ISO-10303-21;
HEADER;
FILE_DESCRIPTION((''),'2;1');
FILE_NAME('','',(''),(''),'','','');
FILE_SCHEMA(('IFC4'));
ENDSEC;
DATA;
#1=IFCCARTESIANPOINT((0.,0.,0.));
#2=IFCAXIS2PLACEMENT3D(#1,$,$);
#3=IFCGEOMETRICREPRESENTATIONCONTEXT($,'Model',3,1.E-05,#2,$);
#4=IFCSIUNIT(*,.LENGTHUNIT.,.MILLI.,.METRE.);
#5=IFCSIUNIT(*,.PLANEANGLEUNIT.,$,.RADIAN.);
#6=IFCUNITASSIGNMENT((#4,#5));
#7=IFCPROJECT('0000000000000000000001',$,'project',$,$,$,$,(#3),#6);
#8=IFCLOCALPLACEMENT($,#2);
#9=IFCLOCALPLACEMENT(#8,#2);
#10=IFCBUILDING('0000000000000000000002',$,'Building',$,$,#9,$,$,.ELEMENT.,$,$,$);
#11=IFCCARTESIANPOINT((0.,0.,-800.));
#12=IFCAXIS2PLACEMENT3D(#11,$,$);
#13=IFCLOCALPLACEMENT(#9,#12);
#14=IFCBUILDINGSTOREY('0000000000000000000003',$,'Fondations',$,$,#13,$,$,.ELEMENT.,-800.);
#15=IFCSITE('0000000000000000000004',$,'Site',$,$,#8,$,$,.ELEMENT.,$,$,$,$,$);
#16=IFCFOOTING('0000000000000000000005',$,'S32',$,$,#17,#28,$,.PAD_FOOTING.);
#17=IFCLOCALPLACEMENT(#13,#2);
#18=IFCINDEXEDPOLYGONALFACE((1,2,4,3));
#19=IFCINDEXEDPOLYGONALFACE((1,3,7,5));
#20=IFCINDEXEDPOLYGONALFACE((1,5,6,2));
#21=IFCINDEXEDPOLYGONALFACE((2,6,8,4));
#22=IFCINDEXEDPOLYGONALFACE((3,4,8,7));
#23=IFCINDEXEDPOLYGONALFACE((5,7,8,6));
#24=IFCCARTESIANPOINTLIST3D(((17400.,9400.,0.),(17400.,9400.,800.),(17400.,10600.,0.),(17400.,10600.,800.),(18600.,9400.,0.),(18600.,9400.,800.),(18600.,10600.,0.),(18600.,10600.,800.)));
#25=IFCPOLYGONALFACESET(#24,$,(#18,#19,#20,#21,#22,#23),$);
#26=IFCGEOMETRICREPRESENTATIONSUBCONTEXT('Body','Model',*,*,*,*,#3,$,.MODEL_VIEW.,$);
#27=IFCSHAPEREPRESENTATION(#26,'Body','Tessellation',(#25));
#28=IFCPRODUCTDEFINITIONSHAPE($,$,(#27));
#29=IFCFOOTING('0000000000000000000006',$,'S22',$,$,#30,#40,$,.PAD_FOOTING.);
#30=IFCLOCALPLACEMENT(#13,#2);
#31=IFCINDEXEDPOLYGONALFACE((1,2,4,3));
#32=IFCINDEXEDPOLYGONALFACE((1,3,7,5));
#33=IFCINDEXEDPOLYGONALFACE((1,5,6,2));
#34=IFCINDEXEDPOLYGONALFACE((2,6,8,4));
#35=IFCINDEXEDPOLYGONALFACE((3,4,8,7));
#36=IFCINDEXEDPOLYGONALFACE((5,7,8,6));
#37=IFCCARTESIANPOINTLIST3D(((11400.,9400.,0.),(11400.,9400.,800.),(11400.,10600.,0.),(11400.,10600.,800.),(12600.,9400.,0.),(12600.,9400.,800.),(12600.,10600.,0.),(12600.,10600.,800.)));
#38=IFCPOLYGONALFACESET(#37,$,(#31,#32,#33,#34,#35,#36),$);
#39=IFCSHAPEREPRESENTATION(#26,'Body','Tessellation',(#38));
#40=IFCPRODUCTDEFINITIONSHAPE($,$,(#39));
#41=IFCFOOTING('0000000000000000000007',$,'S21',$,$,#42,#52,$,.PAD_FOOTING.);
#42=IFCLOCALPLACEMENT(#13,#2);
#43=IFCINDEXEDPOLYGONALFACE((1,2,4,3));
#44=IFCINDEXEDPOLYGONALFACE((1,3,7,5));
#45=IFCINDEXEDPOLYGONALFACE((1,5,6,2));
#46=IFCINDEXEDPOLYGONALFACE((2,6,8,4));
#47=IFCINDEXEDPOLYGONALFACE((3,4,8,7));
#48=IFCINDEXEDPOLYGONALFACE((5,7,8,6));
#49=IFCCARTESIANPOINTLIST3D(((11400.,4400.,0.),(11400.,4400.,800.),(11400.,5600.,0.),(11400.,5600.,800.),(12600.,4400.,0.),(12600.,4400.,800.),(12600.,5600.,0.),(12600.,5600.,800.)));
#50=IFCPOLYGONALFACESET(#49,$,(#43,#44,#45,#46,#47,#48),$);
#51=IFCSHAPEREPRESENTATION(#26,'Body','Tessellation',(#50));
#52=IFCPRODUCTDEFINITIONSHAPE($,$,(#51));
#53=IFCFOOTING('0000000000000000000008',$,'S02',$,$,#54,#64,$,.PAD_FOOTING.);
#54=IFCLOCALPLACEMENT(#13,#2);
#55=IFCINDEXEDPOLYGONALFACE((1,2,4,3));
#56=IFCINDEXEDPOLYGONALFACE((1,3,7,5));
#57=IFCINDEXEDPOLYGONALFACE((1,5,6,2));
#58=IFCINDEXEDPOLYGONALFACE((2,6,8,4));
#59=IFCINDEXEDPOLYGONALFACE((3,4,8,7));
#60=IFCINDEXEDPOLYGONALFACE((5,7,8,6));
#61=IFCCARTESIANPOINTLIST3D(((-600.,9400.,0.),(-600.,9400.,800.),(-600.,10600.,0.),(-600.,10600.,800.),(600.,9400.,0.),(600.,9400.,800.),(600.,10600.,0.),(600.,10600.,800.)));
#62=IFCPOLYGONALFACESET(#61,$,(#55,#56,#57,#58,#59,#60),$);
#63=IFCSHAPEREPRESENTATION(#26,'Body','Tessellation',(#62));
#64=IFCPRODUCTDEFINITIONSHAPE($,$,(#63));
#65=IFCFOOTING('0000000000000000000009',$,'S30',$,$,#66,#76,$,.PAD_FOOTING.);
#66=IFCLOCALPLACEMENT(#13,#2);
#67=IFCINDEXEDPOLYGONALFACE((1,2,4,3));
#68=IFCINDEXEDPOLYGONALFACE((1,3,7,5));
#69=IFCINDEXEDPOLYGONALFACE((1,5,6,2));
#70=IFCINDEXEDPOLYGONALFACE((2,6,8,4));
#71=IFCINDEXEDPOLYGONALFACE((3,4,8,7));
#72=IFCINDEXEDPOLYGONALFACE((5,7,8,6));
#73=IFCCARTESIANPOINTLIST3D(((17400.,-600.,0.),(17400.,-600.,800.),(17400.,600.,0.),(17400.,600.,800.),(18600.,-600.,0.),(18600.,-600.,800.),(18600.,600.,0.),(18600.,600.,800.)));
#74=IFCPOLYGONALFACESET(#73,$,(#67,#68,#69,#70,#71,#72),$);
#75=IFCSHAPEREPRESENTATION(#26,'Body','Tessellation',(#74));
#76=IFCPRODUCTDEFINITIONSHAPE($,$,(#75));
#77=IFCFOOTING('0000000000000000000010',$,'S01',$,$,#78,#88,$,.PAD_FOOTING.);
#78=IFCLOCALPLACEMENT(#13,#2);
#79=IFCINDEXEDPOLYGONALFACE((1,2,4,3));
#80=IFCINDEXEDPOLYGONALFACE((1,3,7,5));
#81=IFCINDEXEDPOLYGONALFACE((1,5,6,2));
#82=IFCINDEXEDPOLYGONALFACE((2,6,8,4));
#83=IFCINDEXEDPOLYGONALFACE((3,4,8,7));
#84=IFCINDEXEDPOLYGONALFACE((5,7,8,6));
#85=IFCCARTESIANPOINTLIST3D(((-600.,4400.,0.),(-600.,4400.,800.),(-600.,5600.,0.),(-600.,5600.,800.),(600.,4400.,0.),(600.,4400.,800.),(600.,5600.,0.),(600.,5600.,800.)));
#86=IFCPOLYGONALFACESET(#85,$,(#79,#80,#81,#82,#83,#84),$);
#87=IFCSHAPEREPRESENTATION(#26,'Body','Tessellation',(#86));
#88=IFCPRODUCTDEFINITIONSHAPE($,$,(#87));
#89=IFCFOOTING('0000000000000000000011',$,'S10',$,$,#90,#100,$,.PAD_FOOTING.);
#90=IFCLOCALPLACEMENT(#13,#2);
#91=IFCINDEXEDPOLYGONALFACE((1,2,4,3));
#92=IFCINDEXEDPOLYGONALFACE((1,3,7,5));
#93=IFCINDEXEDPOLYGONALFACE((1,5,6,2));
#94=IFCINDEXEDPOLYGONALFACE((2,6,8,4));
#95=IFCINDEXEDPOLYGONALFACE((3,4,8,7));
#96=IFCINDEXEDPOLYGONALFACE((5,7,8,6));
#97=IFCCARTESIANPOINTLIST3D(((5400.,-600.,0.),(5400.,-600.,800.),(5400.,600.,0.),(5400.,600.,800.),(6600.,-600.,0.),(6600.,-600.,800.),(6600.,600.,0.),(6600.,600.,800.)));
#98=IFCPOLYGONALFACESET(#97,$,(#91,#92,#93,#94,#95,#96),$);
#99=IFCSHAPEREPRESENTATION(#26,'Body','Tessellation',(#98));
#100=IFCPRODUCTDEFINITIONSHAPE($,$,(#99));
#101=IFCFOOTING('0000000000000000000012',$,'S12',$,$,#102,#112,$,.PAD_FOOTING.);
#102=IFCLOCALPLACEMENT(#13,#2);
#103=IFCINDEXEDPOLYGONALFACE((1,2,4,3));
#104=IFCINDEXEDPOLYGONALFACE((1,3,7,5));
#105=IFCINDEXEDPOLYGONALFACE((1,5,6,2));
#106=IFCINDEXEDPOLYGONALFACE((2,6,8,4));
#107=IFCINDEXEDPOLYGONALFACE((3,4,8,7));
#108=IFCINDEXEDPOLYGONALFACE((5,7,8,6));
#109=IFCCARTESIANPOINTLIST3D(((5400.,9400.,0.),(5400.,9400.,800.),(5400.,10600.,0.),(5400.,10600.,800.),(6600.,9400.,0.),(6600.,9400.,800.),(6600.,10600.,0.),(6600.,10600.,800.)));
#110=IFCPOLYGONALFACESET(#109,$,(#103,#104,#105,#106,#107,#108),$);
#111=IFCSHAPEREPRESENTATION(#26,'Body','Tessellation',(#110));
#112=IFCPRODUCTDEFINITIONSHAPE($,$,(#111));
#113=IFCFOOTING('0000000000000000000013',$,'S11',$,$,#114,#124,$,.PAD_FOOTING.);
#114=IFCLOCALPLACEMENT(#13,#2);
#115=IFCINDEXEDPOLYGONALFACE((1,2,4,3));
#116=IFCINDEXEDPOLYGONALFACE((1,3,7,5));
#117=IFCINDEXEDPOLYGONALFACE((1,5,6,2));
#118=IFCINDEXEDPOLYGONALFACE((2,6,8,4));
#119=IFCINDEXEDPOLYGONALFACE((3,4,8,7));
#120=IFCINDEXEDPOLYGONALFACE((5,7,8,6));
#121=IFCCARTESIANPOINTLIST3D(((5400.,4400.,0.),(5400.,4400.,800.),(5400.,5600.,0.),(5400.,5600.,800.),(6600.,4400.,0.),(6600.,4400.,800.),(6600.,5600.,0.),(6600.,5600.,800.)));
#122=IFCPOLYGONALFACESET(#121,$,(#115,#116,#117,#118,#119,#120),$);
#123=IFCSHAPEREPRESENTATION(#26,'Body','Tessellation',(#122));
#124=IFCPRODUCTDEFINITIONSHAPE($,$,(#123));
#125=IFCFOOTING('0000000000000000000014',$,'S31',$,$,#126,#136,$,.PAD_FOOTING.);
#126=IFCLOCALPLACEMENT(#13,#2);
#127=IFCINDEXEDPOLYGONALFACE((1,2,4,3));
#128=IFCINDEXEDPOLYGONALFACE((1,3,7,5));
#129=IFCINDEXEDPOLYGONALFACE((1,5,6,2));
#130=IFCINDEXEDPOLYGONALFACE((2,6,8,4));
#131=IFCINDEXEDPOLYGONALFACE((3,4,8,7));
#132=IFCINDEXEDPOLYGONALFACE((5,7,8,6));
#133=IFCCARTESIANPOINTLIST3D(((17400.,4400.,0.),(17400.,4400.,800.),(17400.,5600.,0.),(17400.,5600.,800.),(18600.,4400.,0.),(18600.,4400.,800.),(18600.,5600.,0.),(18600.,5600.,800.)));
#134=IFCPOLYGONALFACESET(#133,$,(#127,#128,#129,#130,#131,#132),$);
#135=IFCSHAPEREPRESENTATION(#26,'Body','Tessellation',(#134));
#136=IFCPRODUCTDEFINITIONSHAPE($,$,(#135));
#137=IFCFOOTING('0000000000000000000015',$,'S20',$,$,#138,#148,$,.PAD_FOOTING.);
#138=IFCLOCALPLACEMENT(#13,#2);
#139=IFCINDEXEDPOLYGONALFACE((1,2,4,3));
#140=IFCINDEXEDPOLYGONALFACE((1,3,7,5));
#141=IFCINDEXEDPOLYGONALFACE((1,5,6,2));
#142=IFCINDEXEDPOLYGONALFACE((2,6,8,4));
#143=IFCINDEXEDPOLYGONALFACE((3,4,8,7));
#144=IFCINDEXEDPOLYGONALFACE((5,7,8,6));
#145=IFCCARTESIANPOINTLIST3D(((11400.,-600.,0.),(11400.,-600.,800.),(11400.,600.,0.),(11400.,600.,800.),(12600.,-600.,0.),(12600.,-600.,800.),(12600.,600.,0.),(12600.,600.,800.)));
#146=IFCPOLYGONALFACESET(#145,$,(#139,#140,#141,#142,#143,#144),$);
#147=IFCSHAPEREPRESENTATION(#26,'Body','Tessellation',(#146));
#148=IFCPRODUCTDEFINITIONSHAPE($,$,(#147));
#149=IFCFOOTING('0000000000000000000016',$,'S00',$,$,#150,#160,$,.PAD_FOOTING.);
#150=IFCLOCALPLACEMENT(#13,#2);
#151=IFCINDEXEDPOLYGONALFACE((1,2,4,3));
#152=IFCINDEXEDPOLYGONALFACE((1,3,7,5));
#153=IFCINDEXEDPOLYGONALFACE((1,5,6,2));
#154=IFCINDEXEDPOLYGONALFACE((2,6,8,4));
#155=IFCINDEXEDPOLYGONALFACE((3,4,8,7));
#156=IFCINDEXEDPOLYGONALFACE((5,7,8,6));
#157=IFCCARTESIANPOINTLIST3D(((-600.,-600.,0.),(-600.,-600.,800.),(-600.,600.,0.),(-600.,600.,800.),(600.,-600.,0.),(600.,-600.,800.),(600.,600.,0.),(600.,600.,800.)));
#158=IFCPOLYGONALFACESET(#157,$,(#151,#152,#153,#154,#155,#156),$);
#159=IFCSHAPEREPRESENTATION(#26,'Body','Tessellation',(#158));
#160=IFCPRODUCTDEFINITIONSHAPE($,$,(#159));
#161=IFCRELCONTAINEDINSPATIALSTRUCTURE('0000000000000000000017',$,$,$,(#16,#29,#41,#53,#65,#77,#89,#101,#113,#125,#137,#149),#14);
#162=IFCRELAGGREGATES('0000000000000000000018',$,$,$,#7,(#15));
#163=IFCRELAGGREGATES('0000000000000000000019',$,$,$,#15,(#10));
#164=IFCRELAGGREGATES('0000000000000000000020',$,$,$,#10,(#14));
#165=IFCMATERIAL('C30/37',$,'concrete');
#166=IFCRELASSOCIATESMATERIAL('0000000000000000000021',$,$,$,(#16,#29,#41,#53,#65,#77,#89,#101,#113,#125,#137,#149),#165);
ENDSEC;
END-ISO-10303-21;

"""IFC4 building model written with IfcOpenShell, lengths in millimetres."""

from ifc_helpers import new_model, si_unit, frame, origin, place, context, subcontext, project, spatial, rectangle, extrude, material, element, save


model = new_model("IFC4")

# Units and contexts
model_context = context("Model", 3, precision=1e-05, world=origin())
body_context = subcontext(model_context, "Body", "Model", "MODEL_VIEW")
ifc_project = project(units=[si_unit("LENGTHUNIT", "METRE", prefix="MILLI"), si_unit("PLANEANGLEUNIT", "RADIAN")], contexts=[model_context])

# Site, building, storey
site_placement = place(None, origin())
site = spatial("IfcSite", under=ifc_project, at=site_placement, Name="Site", CompositionType="ELEMENT")
building_placement = place(site_placement, origin())
building = spatial("IfcBuilding", under=site, at=building_placement, Name="Building", CompositionType="ELEMENT")
storey_placement = place(building_placement, frame((0.0, 0.0, -800.0)))
storey = spatial("IfcBuildingStorey", under=building, at=storey_placement, Name="Fondations", CompositionType="ELEMENT", Elevation=-800.0)

# Footings
ifc_material = material(Name="C30/37", Category="concrete")
for number, where, z_axis, x_axis, name in (
    (1, (18000.0, 10000.0, 0.0), (0.0, 0.0, 1.0), (1.0, 0.0, 0.0), "S32"),
    (2, (12000.0, 10000.0, 0.0), (0.0, 0.0, 1.0), (1.0, 0.0, 0.0), "S22"),
    (3, (12000.0, 5000.0, 0.0), (0.0, 0.0, 1.0), (1.0, 0.0, 0.0), "S21"),
    (4, (0.0, 10000.0, 0.0), (0.0, 0.0, 1.0), (1.0, 0.0, 0.0), "S02"),
    (5, (18000.0, 0.0, 0.0), (0.0, 0.0, 1.0), (1.0, 0.0, 0.0), "S30"),
    (6, (0.0, 5000.0, 0.0), (0.0, 0.0, 1.0), (1.0, 0.0, 0.0), "S01"),
    (7, (6000.0, 0.0, 0.0), (0.0, 0.0, 1.0), (1.0, 0.0, 0.0), "S10"),
    (8, (6000.0, 10000.0, 0.0), (0.0, 0.0, 1.0), (1.0, 0.0, 0.0), "S12"),
    (9, (6000.0, 5000.0, 0.0), (0.0, 0.0, 1.0), (1.0, 0.0, 0.0), "S11"),
    (10, (18000.0, 5000.0, 0.0), (0.0, 0.0, 1.0), (1.0, 0.0, 0.0), "S31"),
    (11, (12000.0, 0.0, 0.0), (0.0, 0.0, 1.0), (1.0, 0.0, 0.0), "S20"),
    (12, (0.0, 0.0, 0.0), (0.0, 0.0, 1.0), (1.0, 0.0, 0.0), "S00"),
):
    element("IfcFooting", number, at=place(storey_placement, frame(where, z_axis=z_axis, x_axis=x_axis)), inside=storey, material=ifc_material, Name=name, PredefinedType="PAD_FOOTING", context=body_context, shape_type="SweptSolid", body=[
        extrude(rectangle(XDim=1200.0, YDim=1200.0), origin(), (0.0, 0.0, 1.0), 800.0),
    ])

save(model, "model.ifc")
